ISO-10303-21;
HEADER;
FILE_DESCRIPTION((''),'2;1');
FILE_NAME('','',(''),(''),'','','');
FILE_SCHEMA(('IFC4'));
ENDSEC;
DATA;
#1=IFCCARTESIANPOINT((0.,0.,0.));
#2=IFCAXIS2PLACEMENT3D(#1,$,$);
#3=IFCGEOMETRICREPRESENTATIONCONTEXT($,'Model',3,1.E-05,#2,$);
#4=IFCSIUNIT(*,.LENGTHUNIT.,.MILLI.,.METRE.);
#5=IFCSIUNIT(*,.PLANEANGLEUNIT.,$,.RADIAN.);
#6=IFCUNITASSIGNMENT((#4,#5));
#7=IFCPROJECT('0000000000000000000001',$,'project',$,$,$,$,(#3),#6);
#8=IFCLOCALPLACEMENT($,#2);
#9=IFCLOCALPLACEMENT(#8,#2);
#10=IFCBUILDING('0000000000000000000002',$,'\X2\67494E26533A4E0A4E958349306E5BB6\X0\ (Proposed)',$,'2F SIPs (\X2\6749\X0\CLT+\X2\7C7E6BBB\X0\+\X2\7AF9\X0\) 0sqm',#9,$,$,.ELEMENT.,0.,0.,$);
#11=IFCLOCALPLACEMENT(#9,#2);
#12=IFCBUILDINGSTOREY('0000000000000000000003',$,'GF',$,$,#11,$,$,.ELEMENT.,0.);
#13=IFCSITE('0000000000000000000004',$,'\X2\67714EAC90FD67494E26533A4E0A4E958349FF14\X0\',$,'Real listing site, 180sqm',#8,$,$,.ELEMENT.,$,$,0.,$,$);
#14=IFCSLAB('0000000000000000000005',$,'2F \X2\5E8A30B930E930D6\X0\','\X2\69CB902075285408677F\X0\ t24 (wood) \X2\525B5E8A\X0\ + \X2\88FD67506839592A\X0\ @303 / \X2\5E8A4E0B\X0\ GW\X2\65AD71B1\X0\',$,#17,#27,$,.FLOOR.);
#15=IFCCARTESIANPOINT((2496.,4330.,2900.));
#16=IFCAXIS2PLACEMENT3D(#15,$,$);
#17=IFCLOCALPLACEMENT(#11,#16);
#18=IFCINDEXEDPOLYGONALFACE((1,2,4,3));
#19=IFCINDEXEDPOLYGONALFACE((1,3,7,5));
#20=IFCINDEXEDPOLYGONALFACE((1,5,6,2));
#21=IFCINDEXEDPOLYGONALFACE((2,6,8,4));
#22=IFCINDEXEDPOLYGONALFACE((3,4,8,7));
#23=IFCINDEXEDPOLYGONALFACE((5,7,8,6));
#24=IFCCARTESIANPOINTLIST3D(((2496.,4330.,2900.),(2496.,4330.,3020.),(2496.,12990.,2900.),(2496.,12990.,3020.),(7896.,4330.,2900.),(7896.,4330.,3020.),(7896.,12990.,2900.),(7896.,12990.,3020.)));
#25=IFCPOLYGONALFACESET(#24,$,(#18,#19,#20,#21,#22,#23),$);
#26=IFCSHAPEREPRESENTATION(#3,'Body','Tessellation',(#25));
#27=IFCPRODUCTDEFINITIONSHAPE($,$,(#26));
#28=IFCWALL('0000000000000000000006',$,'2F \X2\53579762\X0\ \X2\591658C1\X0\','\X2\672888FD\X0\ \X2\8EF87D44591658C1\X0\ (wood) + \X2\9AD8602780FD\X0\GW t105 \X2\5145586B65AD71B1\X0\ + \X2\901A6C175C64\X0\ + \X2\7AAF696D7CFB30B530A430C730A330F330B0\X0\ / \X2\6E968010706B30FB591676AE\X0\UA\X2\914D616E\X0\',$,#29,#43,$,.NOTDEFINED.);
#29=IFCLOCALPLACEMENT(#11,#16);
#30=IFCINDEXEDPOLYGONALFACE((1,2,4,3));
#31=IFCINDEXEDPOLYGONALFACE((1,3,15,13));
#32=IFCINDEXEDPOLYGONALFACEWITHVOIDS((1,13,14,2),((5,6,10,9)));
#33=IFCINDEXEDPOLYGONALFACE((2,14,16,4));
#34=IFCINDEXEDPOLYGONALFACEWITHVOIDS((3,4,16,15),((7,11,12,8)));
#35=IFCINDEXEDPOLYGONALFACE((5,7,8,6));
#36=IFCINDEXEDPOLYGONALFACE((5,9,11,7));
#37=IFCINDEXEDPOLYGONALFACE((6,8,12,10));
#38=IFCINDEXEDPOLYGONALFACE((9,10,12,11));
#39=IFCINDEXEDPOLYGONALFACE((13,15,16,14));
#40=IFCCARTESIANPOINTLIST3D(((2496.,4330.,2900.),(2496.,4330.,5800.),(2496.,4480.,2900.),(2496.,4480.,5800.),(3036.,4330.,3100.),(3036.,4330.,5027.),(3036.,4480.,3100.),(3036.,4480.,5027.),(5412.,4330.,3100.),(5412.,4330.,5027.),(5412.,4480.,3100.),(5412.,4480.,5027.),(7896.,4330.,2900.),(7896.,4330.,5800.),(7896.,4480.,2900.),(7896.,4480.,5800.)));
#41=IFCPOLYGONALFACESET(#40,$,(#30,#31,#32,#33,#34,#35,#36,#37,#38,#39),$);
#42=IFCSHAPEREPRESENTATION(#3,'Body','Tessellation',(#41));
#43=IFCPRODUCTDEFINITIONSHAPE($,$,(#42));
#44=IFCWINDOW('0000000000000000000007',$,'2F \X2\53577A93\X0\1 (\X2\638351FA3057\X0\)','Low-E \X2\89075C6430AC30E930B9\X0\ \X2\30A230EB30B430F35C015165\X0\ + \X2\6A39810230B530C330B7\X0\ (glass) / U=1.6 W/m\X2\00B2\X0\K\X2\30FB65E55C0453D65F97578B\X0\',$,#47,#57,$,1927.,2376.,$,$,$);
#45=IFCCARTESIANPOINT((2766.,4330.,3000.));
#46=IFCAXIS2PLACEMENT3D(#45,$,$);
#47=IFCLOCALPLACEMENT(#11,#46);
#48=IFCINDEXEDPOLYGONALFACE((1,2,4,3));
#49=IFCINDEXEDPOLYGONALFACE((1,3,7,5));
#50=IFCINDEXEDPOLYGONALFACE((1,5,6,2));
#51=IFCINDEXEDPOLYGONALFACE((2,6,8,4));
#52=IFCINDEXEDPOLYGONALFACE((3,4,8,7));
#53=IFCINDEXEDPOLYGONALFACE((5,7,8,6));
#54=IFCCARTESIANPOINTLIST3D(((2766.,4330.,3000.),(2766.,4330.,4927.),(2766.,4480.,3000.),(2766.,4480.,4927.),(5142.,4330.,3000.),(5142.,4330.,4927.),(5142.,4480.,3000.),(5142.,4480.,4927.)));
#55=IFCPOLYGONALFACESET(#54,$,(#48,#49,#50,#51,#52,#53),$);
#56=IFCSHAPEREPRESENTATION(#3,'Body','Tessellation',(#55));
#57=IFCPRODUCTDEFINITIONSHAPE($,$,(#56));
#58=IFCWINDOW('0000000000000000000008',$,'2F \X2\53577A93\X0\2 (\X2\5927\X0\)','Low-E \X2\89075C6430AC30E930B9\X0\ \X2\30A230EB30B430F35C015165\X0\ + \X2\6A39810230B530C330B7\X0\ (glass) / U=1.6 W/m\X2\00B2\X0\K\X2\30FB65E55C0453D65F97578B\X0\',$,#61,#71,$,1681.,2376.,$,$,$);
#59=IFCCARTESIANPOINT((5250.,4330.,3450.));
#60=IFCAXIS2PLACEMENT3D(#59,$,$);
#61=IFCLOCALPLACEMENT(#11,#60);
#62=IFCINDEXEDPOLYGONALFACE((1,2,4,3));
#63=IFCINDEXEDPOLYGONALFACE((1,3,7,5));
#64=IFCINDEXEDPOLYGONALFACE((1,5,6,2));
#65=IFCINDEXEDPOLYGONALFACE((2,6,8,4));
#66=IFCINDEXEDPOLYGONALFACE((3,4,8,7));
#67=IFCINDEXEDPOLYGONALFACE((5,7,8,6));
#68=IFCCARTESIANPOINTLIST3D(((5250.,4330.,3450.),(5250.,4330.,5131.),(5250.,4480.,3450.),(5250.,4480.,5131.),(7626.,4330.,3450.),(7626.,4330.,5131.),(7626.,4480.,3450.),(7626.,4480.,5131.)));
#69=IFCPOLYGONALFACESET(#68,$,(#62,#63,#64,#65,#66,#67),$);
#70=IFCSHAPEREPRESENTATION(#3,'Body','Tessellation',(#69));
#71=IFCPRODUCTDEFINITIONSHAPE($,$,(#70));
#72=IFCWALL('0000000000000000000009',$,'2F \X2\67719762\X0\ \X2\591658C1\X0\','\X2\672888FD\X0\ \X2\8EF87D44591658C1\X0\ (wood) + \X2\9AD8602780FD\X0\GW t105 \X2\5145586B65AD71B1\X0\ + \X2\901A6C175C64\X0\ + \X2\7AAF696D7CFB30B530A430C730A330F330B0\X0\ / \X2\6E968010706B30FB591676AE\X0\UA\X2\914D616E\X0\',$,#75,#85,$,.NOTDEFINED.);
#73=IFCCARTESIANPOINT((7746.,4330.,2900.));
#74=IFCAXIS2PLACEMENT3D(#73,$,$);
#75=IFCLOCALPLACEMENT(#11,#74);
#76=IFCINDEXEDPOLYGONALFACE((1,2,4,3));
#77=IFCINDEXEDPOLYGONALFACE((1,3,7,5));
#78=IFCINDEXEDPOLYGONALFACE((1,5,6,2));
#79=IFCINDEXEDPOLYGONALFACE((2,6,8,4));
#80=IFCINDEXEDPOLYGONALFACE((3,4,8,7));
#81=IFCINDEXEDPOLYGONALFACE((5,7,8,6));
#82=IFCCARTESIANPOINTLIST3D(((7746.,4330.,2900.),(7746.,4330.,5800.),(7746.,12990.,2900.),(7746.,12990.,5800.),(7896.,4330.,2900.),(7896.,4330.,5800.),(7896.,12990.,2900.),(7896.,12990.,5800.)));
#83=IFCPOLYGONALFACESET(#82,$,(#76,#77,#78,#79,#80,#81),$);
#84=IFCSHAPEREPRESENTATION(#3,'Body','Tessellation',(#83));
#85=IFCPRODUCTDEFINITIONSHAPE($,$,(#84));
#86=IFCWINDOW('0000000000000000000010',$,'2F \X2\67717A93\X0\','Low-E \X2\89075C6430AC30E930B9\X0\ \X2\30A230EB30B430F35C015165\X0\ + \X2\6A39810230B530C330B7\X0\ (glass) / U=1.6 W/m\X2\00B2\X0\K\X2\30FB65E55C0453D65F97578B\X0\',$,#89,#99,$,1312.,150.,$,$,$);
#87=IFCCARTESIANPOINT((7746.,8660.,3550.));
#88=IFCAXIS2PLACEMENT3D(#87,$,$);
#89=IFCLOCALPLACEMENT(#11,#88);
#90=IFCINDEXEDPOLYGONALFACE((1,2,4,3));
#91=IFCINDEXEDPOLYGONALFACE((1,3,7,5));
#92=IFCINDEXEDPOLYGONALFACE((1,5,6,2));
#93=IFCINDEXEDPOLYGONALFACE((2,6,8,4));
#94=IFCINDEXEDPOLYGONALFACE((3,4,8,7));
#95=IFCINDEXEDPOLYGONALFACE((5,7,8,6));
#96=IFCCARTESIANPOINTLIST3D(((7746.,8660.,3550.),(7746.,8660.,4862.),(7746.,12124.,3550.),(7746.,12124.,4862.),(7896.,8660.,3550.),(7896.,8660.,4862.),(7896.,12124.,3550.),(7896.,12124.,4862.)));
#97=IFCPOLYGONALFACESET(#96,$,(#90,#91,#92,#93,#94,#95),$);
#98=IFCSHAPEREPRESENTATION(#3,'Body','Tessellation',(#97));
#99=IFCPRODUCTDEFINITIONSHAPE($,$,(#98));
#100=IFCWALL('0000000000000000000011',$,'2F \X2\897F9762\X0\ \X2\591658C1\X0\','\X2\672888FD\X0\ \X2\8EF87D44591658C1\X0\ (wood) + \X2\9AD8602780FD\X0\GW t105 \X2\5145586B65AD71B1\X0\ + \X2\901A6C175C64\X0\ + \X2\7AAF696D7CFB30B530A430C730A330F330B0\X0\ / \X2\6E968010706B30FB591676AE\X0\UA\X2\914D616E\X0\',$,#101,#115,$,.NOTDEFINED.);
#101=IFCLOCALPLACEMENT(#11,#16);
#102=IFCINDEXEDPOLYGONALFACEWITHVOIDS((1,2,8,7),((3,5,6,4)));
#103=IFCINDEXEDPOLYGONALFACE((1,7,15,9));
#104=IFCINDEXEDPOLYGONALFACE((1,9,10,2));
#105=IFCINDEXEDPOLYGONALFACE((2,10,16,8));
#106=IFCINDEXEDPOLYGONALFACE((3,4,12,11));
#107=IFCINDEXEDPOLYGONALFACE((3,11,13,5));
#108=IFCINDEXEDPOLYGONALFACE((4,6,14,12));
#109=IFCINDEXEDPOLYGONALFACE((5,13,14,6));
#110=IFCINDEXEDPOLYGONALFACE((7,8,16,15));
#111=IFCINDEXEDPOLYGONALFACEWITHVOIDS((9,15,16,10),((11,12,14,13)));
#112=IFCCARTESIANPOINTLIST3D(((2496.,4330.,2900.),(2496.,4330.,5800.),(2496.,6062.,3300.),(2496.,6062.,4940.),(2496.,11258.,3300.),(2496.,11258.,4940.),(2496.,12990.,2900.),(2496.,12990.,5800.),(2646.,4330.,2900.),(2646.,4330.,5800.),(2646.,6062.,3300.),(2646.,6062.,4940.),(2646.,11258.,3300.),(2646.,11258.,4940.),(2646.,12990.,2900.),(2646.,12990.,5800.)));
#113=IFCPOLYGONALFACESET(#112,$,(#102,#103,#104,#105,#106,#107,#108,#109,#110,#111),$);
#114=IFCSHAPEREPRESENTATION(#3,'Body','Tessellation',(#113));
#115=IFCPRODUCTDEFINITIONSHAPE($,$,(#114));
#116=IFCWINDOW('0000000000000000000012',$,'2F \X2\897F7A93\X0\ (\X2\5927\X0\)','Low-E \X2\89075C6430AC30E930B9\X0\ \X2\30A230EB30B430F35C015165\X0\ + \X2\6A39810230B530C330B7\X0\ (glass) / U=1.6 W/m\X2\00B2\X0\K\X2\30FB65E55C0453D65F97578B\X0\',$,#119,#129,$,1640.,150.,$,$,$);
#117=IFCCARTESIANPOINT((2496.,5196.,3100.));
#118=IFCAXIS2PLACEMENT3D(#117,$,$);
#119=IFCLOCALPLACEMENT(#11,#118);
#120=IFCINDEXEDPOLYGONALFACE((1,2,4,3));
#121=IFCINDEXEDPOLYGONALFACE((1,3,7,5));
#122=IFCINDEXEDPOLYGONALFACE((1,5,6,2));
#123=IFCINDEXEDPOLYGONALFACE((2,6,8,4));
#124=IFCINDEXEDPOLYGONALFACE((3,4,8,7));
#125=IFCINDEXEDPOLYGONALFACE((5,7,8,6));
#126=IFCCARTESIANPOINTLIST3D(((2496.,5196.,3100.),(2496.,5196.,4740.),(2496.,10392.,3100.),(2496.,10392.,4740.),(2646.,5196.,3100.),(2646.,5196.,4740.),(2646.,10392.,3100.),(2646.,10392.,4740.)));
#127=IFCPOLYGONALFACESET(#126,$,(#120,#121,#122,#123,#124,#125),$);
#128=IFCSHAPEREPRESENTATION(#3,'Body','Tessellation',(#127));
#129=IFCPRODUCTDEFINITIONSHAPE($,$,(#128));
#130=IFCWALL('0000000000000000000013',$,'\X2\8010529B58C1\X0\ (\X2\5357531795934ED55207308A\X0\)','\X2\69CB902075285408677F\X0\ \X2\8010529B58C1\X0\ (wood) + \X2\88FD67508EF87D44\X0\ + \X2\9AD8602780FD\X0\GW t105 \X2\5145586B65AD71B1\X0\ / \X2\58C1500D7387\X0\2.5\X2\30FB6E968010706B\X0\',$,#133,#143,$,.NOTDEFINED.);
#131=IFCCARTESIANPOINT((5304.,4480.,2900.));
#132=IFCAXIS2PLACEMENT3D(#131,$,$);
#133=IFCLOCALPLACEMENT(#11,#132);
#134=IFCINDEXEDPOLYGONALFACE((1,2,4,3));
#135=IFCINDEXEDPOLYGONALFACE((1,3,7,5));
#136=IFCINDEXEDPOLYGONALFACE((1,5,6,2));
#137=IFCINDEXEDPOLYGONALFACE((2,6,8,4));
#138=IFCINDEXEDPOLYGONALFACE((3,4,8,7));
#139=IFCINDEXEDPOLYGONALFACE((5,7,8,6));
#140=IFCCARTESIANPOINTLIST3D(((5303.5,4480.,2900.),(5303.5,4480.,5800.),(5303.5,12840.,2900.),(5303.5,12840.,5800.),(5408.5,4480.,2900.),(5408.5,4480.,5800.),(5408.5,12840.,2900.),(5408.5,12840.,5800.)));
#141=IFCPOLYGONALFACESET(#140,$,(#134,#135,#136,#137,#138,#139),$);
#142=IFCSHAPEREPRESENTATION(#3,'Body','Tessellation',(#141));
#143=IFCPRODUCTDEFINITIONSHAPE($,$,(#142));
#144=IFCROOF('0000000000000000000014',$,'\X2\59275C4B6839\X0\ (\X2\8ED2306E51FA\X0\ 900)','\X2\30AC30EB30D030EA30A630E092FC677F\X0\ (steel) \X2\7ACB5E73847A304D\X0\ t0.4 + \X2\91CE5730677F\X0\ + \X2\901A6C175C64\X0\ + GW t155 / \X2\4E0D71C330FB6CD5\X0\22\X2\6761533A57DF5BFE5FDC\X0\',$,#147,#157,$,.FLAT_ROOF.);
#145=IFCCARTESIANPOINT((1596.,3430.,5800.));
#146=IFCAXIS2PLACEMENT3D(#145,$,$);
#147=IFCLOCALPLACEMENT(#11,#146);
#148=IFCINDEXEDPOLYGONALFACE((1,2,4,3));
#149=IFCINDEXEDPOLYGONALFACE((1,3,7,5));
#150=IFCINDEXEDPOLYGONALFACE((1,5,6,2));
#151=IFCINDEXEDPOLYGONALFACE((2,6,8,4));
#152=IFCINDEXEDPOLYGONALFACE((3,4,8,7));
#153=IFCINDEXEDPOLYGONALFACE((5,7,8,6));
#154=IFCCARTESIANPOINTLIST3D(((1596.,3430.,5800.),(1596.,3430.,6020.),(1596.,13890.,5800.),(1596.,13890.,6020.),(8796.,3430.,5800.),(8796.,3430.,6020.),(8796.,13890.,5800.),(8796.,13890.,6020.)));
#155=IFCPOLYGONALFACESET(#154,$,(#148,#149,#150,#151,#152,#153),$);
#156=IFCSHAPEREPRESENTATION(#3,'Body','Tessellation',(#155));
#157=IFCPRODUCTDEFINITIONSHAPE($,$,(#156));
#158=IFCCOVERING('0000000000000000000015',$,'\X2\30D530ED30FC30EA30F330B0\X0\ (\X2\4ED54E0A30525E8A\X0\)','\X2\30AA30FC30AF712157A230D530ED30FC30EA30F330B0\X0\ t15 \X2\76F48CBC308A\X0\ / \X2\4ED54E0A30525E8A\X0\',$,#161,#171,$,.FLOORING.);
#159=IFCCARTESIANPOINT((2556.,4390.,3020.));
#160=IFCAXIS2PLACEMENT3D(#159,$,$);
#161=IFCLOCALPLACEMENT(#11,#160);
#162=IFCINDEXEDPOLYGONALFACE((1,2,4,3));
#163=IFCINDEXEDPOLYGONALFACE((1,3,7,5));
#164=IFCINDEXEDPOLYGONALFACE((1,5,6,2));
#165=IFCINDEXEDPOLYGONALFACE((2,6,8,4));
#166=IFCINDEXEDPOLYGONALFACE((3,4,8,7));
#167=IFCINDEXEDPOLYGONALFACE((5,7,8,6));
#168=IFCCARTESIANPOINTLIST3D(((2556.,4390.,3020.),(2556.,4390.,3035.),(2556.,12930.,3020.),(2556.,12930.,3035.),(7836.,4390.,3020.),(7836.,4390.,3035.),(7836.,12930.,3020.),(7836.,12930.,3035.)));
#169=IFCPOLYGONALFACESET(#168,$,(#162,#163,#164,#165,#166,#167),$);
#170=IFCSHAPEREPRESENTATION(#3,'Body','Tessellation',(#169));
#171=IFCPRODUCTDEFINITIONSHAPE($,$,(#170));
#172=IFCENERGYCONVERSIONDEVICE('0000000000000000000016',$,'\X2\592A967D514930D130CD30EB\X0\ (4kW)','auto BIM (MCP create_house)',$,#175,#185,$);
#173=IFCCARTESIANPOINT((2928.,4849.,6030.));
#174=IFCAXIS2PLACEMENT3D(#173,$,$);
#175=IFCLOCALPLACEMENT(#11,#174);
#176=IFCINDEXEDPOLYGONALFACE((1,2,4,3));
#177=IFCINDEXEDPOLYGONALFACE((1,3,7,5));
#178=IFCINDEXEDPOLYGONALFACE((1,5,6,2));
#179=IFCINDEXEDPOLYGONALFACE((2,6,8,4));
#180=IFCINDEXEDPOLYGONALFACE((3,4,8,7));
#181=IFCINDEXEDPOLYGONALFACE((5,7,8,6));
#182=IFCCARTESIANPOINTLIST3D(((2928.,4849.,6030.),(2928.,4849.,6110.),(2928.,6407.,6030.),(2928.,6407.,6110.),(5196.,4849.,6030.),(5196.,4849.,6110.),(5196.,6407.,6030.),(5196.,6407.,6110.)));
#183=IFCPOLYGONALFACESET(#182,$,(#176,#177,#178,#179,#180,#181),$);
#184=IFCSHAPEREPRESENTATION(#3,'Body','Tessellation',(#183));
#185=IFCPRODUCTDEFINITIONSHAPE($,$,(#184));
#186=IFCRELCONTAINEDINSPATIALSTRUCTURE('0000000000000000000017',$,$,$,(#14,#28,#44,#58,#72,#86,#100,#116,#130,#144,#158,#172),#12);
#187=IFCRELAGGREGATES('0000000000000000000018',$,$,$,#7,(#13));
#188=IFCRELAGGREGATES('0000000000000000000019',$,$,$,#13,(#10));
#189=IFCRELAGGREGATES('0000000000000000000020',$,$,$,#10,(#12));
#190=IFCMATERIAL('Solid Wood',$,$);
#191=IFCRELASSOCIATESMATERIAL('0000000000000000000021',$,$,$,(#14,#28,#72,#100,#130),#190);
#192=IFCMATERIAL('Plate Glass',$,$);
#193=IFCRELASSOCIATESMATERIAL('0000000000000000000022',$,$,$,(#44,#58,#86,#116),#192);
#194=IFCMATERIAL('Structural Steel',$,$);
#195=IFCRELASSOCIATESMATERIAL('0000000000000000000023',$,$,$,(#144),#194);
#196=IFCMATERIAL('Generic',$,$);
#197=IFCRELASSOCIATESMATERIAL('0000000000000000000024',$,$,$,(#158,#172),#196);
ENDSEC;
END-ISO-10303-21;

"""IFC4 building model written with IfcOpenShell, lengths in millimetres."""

from ifc_helpers import new_model, si_unit, frame, frame_2d, origin, place, context, project, spatial, rectangle, extrude, material, element, fill, save


model = new_model("IFC4")

# Units and contexts
model_context = context("Model", 3, precision=1e-05, world=origin())
ifc_project = project(units=[si_unit("LENGTHUNIT", "METRE", prefix="MILLI"), si_unit("PLANEANGLEUNIT", "RADIAN")], contexts=[model_context])

# Site, building, storey
site_placement = place(None, origin())
site = spatial("IfcSite", under=ifc_project, at=site_placement, Name="東京都杉並区上井草４", ObjectType="Real listing site, 180sqm", CompositionType="ELEMENT", RefElevation=0.0)
building_placement = place(site_placement, origin())
building = spatial("IfcBuilding", under=site, at=building_placement, Name="杉並区上井草の家 (Proposed)", ObjectType="2F SIPs (杉CLT+籾殻+竹) 0sqm", CompositionType="ELEMENT", ElevationOfRefHeight=0.0, ElevationOfTerrain=0.0)
storey_placement = place(building_placement, origin())
storey = spatial("IfcBuildingStorey", under=building, at=storey_placement, Name="GF", CompositionType="ELEMENT", Elevation=0.0)

# Slab
ifc_material_1 = material(Name="Solid Wood")
slab_placement = place(storey_placement, frame((2496.0, 4330.0, 2900.0)))
element("IfcSlab", 1, at=slab_placement, inside=storey, material=ifc_material_1, Name="2F 床スラブ", Description="構造用合板 t24 (wood) 剛床 + 製材根太 @303 / 床下 GW断熱", PredefinedType="FLOOR", context=model_context, shape_type="SweptSolid", body=[
    extrude(rectangle(XDim=5400.0, YDim=8660.0, at=frame_2d((2700.0, 4330.0))), frame((2496.0, 4330.0, 2900.0)), (0.0, 0.0, 1.0), 120.0),
])

# Wall, openings, windows
wall_1_placement = place(storey_placement, frame((2496.0, 4330.0, 2900.0)))
wall_1 = element("IfcWall", 2, at=wall_1_placement, inside=storey, material=ifc_material_1, Name="2F 南面 外壁", Description="木製 軸組外壁 (wood) + 高性能GW t105 充填断熱 + 通気層 + 窯業系サイディング / 準耐火・外皮UA配慮", PredefinedType="NOTDEFINED", context=model_context, shape_type="SweptSolid", body=[
    extrude(rectangle(XDim=5400.0, YDim=150.0, at=frame_2d((2700.0, 75.0))), frame((2496.0, 4330.0, 2900.0)), (0.0, 0.0, 1.0), 2900.0),
])
opening_1_placement = place(storey_placement, frame((2766.0, 4330.0, 3000.0)))
opening_1 = element("IfcOpeningElement", 3, at=opening_1_placement, cuts=wall_1, PredefinedType="NOTDEFINED", context=model_context, shape_type="SweptSolid", body=[
    extrude(rectangle(XDim=2376.0, YDim=150.0, at=frame_2d((1188.0, 75.0))), frame((2766.0, 4330.0, 3000.0)), (0.0, 0.0, 1.0), 1927.0),
])
opening_2_placement = place(storey_placement, frame((5250.0, 4330.0, 3450.0)))
opening_2 = element("IfcOpeningElement", 4, at=opening_2_placement, cuts=wall_1, PredefinedType="NOTDEFINED", context=model_context, shape_type="SweptSolid", body=[
    extrude(rectangle(XDim=2376.0, YDim=150.0, at=frame_2d((1188.0, 75.0))), frame((5250.0, 4330.0, 3450.0)), (0.0, 0.0, 1.0), 1681.0),
])
ifc_material_2 = material(Name="Plate Glass")
window_1_placement = place(storey_placement, frame((2766.0, 4330.0, 3000.0)))
window_1 = element("IfcWindow", 5, at=window_1_placement, inside=storey, material=ifc_material_2, Name="2F 南窓1 (掃出し)", Description="Low-E 複層ガラス アルゴン封入 + 樹脂サッシ (glass) / U=1.6 W/m²K・日射取得型", OverallHeight=1927.0, OverallWidth=2376.0, context=model_context, shape_type="SweptSolid", body=[
    extrude(rectangle(XDim=2376.0, YDim=150.0, at=frame_2d((1188.0, 75.0))), frame((2766.0, 4330.0, 3000.0)), (0.0, 0.0, 1.0), 1927.0),
])
fill(opening_1, window_1)
window_2_placement = place(storey_placement, frame((5250.0, 4330.0, 3450.0)))
window_2 = element("IfcWindow", 6, at=window_2_placement, inside=storey, material=ifc_material_2, Name="2F 南窓2 (大)", Description="Low-E 複層ガラス アルゴン封入 + 樹脂サッシ (glass) / U=1.6 W/m²K・日射取得型", OverallHeight=1681.0, OverallWidth=2376.0, context=model_context, shape_type="SweptSolid", body=[
    extrude(rectangle(XDim=2376.0, YDim=150.0, at=frame_2d((1188.0, 75.0))), frame((5250.0, 4330.0, 3450.0)), (0.0, 0.0, 1.0), 1681.0),
])
fill(opening_2, window_2)

# Walls, openings, windows
wall_2_placement = place(storey_placement, frame((7746.0, 4330.0, 2900.0)))
wall_2 = element("IfcWall", 7, at=wall_2_placement, inside=storey, material=ifc_material_1, Name="2F 東面 外壁", Description="木製 軸組外壁 (wood) + 高性能GW t105 充填断熱 + 通気層 + 窯業系サイディング / 準耐火・外皮UA配慮", PredefinedType="NOTDEFINED", context=model_context, shape_type="SweptSolid", body=[
    extrude(rectangle(XDim=150.0, YDim=8660.0, at=frame_2d((75.0, 4330.0))), frame((7746.0, 4330.0, 2900.0)), (0.0, 0.0, 1.0), 2900.0),
])
opening_3_placement = place(storey_placement, frame((7746.0, 8660.0, 3550.0)))
opening_3 = element("IfcOpeningElement", 8, at=opening_3_placement, cuts=wall_2, PredefinedType="NOTDEFINED", context=model_context, shape_type="SweptSolid", body=[
    extrude(rectangle(XDim=150.0, YDim=3464.0, at=frame_2d((75.0, 1732.0))), frame((7746.0, 8660.0, 3550.0)), (0.0, 0.0, 1.0), 1312.0),
])
window_3_placement = place(storey_placement, frame((7746.0, 8660.0, 3550.0)))
window_3 = element("IfcWindow", 9, at=window_3_placement, inside=storey, material=ifc_material_2, Name="2F 東窓", Description="Low-E 複層ガラス アルゴン封入 + 樹脂サッシ (glass) / U=1.6 W/m²K・日射取得型", OverallHeight=1312.0, OverallWidth=150.0, context=model_context, shape_type="SweptSolid", body=[
    extrude(rectangle(XDim=150.0, YDim=3464.0, at=frame_2d((75.0, 1732.0))), frame((7746.0, 8660.0, 3550.0)), (0.0, 0.0, 1.0), 1312.0),
])
fill(opening_3, window_3)
wall_3_placement = place(storey_placement, frame((2496.0, 4330.0, 2900.0)))
wall_3 = element("IfcWall", 10, at=wall_3_placement, inside=storey, material=ifc_material_1, Name="2F 西面 外壁", Description="木製 軸組外壁 (wood) + 高性能GW t105 充填断熱 + 通気層 + 窯業系サイディング / 準耐火・外皮UA配慮", PredefinedType="NOTDEFINED", context=model_context, shape_type="SweptSolid", body=[
    extrude(rectangle(XDim=150.0, YDim=8660.0, at=frame_2d((75.0, 4330.0))), frame((2496.0, 4330.0, 2900.0)), (0.0, 0.0, 1.0), 2900.0),
])
opening_4_placement = place(storey_placement, frame((2496.0, 5196.0, 3100.0)))
opening_4 = element("IfcOpeningElement", 11, at=opening_4_placement, cuts=wall_3, PredefinedType="NOTDEFINED", context=model_context, shape_type="SweptSolid", body=[
    extrude(rectangle(XDim=150.0, YDim=5196.0, at=frame_2d((75.0, 2598.0))), frame((2496.0, 5196.0, 3100.0)), (0.0, 0.0, 1.0), 1640.0),
])
window_4_placement = place(storey_placement, frame((2496.0, 5196.0, 3100.0)))
window_4 = element("IfcWindow", 12, at=window_4_placement, inside=storey, material=ifc_material_2, Name="2F 西窓 (大)", Description="Low-E 複層ガラス アルゴン封入 + 樹脂サッシ (glass) / U=1.6 W/m²K・日射取得型", OverallHeight=1640.0, OverallWidth=150.0, context=model_context, shape_type="SweptSolid", body=[
    extrude(rectangle(XDim=150.0, YDim=5196.0, at=frame_2d((75.0, 2598.0))), frame((2496.0, 5196.0, 3100.0)), (0.0, 0.0, 1.0), 1640.0),
])
fill(opening_4, window_4)

# Wall
wall_4_placement = place(storey_placement, frame((5304.0, 4480.0, 2900.0)))
element("IfcWall", 13, at=wall_4_placement, inside=storey, material=ifc_material_1, Name="耐力壁 (南北間仕切り)", Description="構造用合板 耐力壁 (wood) + 製材軸組 + 高性能GW t105 充填断熱 / 壁倍率2.5・準耐火", PredefinedType="NOTDEFINED", context=model_context, shape_type="SweptSolid", body=[
    extrude(rectangle(XDim=105.0, YDim=8360.0, at=frame_2d((52.0, 4180.0))), frame((5304.0, 4480.0, 2900.0)), (0.0, 0.0, 1.0), 2900.0),
])

# Roof
ifc_material_3 = material(Name="Structural Steel")
roof_placement = place(storey_placement, frame((1596.0, 3430.0, 5800.0)))
element("IfcRoof", 14, at=roof_placement, inside=storey, material=ifc_material_3, Name="大屋根 (軒の出 900)", Description="ガルバリウム鋼板 (steel) 立平葺き t0.4 + 野地板 + 通気層 + GW t155 / 不燃・法22条区域対応", PredefinedType="FLAT_ROOF", context=model_context, shape_type="SweptSolid", body=[
    extrude(rectangle(XDim=7200.0, YDim=10460.0, at=frame_2d((3600.0, 5230.0))), frame((1596.0, 3430.0, 5800.0)), (0.0, 0.0, 1.0), 220.0),
])

# Covering
ifc_material_4 = material(Name="Generic")
covering_placement = place(storey_placement, frame((2556.0, 4390.0, 3020.0)))
element("IfcCovering", 15, at=covering_placement, inside=storey, material=ifc_material_4, Name="フローリング (仕上げ床)", Description="オーク無垢フローリング t15 直貼り / 仕上げ床", PredefinedType="FLOORING", context=model_context, shape_type="SweptSolid", body=[
    extrude(rectangle(XDim=5280.0, YDim=8540.0, at=frame_2d((2640.0, 4270.0))), frame((2556.0, 4390.0, 3020.0)), (0.0, 0.0, 1.0), 15.0),
])

# Energy conversion device
energy_conversion_device_placement = place(storey_placement, frame((2928.0, 4849.0, 6030.0)))
element("IfcEnergyConversionDevice", 16, at=energy_conversion_device_placement, inside=storey, material=ifc_material_4, Name="太陽光パネル (4kW)", Description="auto BIM (MCP create_house)", context=model_context, shape_type="SweptSolid", body=[
    extrude(rectangle(XDim=2268.0, YDim=1558.0, at=frame_2d((1134.0, 779.0))), frame((2928.0, 4849.0, 6030.0)), (0.0, 0.0, 1.0), 80.0),
])

save(model, "model.ifc")
